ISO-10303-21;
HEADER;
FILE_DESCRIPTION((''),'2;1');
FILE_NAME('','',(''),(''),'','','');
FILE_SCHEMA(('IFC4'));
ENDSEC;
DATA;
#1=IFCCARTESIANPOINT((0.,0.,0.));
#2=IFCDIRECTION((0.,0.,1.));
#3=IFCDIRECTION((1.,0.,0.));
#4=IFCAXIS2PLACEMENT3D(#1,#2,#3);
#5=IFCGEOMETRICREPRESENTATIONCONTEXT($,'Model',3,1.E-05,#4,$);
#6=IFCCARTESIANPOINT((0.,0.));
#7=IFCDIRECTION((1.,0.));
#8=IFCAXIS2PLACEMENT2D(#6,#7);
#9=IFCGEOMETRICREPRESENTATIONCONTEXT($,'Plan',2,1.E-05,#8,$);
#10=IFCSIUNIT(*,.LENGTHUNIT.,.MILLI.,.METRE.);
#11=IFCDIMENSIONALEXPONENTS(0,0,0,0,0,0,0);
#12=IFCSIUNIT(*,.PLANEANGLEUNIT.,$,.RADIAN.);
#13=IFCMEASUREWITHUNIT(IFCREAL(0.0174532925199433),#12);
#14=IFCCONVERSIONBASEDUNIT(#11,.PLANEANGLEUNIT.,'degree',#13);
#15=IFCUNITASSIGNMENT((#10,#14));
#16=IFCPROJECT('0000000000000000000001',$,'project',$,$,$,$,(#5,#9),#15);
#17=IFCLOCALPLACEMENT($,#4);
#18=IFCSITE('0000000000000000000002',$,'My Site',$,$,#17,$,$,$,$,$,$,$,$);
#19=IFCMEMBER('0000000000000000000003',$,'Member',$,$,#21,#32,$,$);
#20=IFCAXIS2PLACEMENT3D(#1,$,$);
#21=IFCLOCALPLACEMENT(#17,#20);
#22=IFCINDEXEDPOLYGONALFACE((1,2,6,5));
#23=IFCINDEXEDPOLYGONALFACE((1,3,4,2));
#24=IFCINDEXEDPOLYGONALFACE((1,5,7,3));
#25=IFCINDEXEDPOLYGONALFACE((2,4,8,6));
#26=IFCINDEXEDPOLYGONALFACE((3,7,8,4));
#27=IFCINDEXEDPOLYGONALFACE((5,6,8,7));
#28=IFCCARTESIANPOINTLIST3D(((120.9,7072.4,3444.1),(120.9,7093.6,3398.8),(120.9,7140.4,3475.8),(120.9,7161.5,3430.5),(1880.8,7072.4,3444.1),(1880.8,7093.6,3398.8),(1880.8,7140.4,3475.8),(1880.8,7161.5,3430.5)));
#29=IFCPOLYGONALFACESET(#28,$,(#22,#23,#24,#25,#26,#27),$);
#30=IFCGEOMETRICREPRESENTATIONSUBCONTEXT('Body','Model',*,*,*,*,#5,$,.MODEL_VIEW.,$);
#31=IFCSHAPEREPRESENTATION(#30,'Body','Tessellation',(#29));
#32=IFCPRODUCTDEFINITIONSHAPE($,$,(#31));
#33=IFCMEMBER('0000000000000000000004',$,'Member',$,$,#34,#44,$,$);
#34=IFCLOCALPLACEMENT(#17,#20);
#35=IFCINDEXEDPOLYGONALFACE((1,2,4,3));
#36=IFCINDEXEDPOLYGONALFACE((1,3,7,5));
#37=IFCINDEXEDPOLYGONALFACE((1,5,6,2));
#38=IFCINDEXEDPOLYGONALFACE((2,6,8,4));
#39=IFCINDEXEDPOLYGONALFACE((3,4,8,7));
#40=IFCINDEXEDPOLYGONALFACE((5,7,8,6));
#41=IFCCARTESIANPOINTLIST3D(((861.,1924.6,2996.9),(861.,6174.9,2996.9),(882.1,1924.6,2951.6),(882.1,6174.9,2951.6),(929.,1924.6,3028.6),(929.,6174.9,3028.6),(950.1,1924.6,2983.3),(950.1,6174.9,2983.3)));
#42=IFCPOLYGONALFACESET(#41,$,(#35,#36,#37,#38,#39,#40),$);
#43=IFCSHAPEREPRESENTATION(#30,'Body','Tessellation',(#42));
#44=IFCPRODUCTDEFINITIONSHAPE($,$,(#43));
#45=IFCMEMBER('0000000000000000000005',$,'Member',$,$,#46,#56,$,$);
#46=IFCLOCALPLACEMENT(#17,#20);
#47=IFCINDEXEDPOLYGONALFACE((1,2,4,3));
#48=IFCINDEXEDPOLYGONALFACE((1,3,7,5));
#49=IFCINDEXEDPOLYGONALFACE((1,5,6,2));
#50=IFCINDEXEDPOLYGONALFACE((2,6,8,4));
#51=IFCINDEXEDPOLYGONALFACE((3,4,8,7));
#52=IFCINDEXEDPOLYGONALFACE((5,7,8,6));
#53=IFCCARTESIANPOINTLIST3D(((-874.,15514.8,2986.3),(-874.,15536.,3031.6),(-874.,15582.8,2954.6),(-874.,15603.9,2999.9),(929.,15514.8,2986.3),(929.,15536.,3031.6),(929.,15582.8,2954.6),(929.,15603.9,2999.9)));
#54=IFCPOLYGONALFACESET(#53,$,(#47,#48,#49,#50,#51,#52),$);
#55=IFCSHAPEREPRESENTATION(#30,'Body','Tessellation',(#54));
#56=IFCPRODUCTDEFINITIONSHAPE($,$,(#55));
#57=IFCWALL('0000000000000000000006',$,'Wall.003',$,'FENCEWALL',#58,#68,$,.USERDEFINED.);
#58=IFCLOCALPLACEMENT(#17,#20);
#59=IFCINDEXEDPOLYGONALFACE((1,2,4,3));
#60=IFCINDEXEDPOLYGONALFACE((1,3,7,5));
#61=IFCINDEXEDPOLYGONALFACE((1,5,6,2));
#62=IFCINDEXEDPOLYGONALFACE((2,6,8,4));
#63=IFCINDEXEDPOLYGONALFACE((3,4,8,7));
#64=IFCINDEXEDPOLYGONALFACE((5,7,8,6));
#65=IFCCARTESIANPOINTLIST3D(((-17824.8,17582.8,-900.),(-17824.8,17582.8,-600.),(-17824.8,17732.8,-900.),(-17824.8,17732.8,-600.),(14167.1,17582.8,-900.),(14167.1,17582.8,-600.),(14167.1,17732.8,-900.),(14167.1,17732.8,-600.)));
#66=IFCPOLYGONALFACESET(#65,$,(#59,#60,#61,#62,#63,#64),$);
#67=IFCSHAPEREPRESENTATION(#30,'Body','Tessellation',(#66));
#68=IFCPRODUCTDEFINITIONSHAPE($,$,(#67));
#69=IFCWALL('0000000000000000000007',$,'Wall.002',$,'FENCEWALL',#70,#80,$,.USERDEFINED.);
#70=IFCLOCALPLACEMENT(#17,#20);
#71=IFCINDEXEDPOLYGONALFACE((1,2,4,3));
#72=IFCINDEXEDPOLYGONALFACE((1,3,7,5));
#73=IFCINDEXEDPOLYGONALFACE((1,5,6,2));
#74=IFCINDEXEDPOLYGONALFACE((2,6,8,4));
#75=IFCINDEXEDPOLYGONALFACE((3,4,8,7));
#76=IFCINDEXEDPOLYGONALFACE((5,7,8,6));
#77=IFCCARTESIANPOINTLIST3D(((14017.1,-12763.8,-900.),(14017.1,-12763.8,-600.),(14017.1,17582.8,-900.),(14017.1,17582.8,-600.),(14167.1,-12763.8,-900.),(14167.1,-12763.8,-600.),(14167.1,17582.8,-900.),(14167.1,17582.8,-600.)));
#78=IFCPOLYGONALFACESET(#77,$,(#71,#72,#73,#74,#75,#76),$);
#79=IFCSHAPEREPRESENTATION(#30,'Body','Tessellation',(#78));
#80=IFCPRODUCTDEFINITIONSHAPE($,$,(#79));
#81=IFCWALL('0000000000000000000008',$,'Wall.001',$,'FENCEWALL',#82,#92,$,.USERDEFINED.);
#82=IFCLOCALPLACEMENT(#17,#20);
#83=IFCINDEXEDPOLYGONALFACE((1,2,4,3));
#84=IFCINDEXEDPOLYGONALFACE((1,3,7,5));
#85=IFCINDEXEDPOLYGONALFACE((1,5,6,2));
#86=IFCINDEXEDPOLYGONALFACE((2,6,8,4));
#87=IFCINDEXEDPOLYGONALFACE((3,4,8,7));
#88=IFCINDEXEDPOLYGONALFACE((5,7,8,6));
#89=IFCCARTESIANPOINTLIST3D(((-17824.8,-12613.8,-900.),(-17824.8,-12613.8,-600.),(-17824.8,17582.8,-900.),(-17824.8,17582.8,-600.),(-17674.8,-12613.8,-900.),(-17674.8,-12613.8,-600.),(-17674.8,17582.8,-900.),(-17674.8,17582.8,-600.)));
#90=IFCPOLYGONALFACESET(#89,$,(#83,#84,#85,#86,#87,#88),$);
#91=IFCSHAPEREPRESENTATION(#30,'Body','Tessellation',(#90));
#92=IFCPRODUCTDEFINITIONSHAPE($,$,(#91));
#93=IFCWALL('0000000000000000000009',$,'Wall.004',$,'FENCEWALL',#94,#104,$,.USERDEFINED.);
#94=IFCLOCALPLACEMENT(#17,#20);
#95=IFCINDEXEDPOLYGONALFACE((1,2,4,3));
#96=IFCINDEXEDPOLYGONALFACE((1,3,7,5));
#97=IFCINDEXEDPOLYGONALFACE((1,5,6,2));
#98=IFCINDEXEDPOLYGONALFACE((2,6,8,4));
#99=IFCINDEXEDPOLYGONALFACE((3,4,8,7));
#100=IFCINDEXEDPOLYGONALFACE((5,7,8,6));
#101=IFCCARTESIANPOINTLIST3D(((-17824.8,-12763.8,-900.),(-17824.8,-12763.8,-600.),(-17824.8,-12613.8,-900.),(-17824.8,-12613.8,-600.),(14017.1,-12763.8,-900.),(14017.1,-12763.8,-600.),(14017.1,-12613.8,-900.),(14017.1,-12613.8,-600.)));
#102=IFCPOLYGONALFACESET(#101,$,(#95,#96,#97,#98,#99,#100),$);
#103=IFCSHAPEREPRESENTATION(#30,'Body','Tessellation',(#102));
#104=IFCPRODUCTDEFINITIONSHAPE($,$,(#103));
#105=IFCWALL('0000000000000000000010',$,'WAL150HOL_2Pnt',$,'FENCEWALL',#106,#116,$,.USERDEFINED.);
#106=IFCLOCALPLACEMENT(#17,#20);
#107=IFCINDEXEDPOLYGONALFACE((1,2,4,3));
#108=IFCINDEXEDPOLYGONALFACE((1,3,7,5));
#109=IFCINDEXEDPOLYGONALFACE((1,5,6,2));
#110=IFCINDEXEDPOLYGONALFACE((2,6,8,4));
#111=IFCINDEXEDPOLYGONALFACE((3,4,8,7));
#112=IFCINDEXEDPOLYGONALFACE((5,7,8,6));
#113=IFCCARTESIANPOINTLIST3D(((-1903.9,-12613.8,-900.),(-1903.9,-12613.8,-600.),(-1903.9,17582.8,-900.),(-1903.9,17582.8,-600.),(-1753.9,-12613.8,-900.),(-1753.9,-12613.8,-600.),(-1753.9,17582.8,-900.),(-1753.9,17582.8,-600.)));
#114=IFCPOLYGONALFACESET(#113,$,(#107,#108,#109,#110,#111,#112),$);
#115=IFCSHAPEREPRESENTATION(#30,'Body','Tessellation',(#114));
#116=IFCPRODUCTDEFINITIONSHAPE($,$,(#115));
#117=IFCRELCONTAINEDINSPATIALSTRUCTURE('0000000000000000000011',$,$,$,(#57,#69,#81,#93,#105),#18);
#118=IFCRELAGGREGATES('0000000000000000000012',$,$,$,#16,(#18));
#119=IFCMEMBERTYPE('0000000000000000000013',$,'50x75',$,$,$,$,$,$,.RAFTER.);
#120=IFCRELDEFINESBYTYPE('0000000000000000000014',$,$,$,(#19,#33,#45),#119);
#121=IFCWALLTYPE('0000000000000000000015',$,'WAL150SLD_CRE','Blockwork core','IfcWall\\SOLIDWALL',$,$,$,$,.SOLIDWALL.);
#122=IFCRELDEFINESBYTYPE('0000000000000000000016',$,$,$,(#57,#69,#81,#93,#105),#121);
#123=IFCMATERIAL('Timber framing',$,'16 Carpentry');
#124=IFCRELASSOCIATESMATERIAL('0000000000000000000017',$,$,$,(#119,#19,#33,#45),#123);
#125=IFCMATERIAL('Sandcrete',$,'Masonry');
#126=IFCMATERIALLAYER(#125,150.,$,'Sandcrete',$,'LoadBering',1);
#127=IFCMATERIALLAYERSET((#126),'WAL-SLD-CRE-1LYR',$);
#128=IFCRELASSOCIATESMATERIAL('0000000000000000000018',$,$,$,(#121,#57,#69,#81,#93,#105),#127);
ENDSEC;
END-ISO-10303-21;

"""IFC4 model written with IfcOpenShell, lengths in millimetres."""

from ifc_helpers import new_model, entity, si_unit, converted_unit, frame, origin_with_axes, origin_2d_with_axis, place, context, subcontext, project, spatial, indexed_curve, rectangle, outline, extrude, material, layer, layer_set, layer_usage, material_profile, profile_set, profile_usage, type_object, element, save


model = new_model("IFC4")

# Units and contexts
model_context = context("Model", 3, precision=1e-05, world=origin_with_axes())
plan_context = context("Plan", 2, precision=1e-05, world=origin_2d_with_axis())
body_context = subcontext(model_context, "Body", "Model", "MODEL_VIEW")
ifc_project = project(units=[si_unit("LENGTHUNIT", "METRE", prefix="MILLI"), converted_unit("PLANEANGLEUNIT", "degree", entity("IfcReal", 0.0174532925199433), si_unit("PLANEANGLEUNIT", "RADIAN"), dimensions=[0, 0, 0, 0, 0, 0, 0])], contexts=[model_context, plan_context])

# Members
ifc_material_1 = material(Name="Timber framing", Category="16 Carpentry")
ifc_material_profile = material_profile(ifc_material_1, rectangle(XDim=50.0, YDim=75.0), Name="Lumber2", Category="Substrate", Priority=2)
ifc_profile_set = profile_set([ifc_material_profile])
ifc_profile_usage_1 = profile_usage(ifc_profile_set, cardinal=5)
member_type = type_object("IfcMemberType", Name="50x75", PredefinedType="RAFTER", material=ifc_profile_set)
member_1_placement = place(None, frame((1880.8, 7117.0, 3437.3), z_axis=(-1.0, 0.0, 0.0), x_axis=(0.0, -0.422618, 0.906308)))
element("IfcMember", 1, at=member_1_placement, type_object=member_type, material=ifc_profile_usage_1, Name="Member", context=body_context, shape_type="SweptSolid", body=[
    extrude(rectangle(XDim=50.0, YDim=75.0), origin_with_axes(), (0.0, 0.0, 1.0), 1759.9),
])
ifc_profile_usage_2 = profile_usage(ifc_profile_set, cardinal=5)
member_2_placement = place(None, frame((905.6, 1924.6, 2990.1), z_axis=(0.0, 1.0, 0.0), x_axis=(-0.422618, 0.0, 0.906308)))
element("IfcMember", 2, at=member_2_placement, type_object=member_type, material=ifc_profile_usage_2, Name="Member", context=body_context, shape_type="SweptSolid", body=[
    extrude(rectangle(XDim=50.0, YDim=75.0), origin_with_axes(), (0.0, 0.0, 1.0), 4250.4),
])
ifc_profile_usage_3 = profile_usage(ifc_profile_set, cardinal=5)
member_3_placement = place(None, frame((929.0, 15559.4, 2993.1), z_axis=(-1.0, 0.0, 0.0), x_axis=(0.0, -0.422618, -0.906308)))
element("IfcMember", 3, at=member_3_placement, type_object=member_type, material=ifc_profile_usage_3, Name="Member", context=body_context, shape_type="SweptSolid", body=[
    extrude(rectangle(XDim=50.0, YDim=75.0), origin_with_axes(), (0.0, 0.0, 1.0), 1803.0),
])

# Site
site_placement = place(None, origin_with_axes())
site = spatial("IfcSite", under=ifc_project, at=site_placement, Name="My Site")

# Walls
ifc_material_2 = material(Name="Sandcrete", Category="Masonry")
ifc_layer = layer(ifc_material_2, 150.0, Name="Sandcrete", Category="LoadBering", Priority=1)
ifc_layer_set = layer_set([ifc_layer], Name="WAL-SLD-CRE-1LYR")
ifc_layer_usage_1 = layer_usage(ifc_layer_set, "AXIS2", "POSITIVE", 0.0)
wall_type = type_object("IfcWallType", Name="WAL150SLD_CRE", Description="Blockwork core", ApplicableOccurrence="IfcWall\\SOLIDWALL", PredefinedType="SOLIDWALL", material=ifc_layer_set)
wall_1_placement = place(site_placement, frame((-17824.8, 17582.8, -900.0), z_axis=(0.0, 0.0, 1.0), x_axis=(1.0, 0.0, 0.0)))
element("IfcWall", 4, at=wall_1_placement, inside=site, type_object=wall_type, material=ifc_layer_usage_1, Name="Wall.003", ObjectType="FENCEWALL", PredefinedType="USERDEFINED", context=body_context, shape_type="SweptSolid", body=[
    extrude(outline(indexed_curve([(0.0, 0.0), (0.0, 150.0), (31991.9, 150.0), (31991.9, 0.0), (0.0, 0.0)], self_intersect=False)), origin_with_axes(), (0.0, 0.0, 1.0), 300.0),
])
ifc_layer_usage_2 = layer_usage(ifc_layer_set, "AXIS2", "POSITIVE", 0.0)
wall_2_placement = place(site_placement, frame((14017.1, 17582.8, -900.0), z_axis=(0.0, 0.0, 1.0), x_axis=(-0.000001, -1.0, 0.0)))
element("IfcWall", 5, at=wall_2_placement, inside=site, type_object=wall_type, material=ifc_layer_usage_2, Name="Wall.002", ObjectType="FENCEWALL", PredefinedType="USERDEFINED", context=body_context, shape_type="SweptSolid", body=[
    extrude(outline(indexed_curve([(0.0, 0.0), (0.0, 150.0), (30346.6, 150.0), (30346.6, 0.0), (0.0, 0.0)], self_intersect=False)), origin_with_axes(), (0.0, 0.0, 1.0), 300.0),
])
ifc_layer_usage_3 = layer_usage(ifc_layer_set, "AXIS2", "POSITIVE", 0.0)
wall_3_placement = place(site_placement, frame((-17824.8, 17582.8, -900.0), z_axis=(0.0, 0.0, 1.0), x_axis=(-0.000001, -1.0, 0.0)))
element("IfcWall", 6, at=wall_3_placement, inside=site, type_object=wall_type, material=ifc_layer_usage_3, Name="Wall.001", ObjectType="FENCEWALL", PredefinedType="USERDEFINED", context=body_context, shape_type="SweptSolid", body=[
    extrude(outline(indexed_curve([(0.0, 0.0), (0.0, 150.0), (30196.6, 150.0), (30196.6, 0.0), (0.0, 0.0)], self_intersect=False)), origin_with_axes(), (0.0, 0.0, 1.0), 300.0),
])
ifc_layer_usage_4 = layer_usage(ifc_layer_set, "AXIS2", "POSITIVE", 0.0)
wall_4_placement = place(site_placement, frame((14017.1, -12613.8, -900.0), z_axis=(0.0, 0.0, 1.0), x_axis=(-1.0, 0.0, 0.0)))
element("IfcWall", 7, at=wall_4_placement, inside=site, type_object=wall_type, material=ifc_layer_usage_4, Name="Wall.004", ObjectType="FENCEWALL", PredefinedType="USERDEFINED", context=body_context, shape_type="SweptSolid", body=[
    extrude(outline(indexed_curve([(0.0, 0.0), (0.0, 150.0), (31841.9, 150.0), (31841.9, 0.0), (0.0, 0.0)], self_intersect=False)), origin_with_axes(), (0.0, 0.0, 1.0), 300.0),
])
ifc_layer_usage_5 = layer_usage(ifc_layer_set, "AXIS2", "POSITIVE", 0.0)
wall_5_placement = place(site_placement, frame((-1903.9, 17582.8, -900.0), z_axis=(0.0, 0.0, 1.0), x_axis=(-0.000001, -1.0, 0.0)))
element("IfcWall", 8, at=wall_5_placement, inside=site, type_object=wall_type, material=ifc_layer_usage_5, Name="WAL150HOL_2Pnt", ObjectType="FENCEWALL", PredefinedType="USERDEFINED", context=body_context, shape_type="SweptSolid", body=[
    extrude(outline(indexed_curve([(0.0, 0.0), (0.0, 150.0), (30196.6, 150.0), (30196.6, 0.0), (0.0, 0.0)], self_intersect=False)), origin_with_axes(), (0.0, 0.0, 1.0), 300.0),
])

save(model, "model.ifc")
